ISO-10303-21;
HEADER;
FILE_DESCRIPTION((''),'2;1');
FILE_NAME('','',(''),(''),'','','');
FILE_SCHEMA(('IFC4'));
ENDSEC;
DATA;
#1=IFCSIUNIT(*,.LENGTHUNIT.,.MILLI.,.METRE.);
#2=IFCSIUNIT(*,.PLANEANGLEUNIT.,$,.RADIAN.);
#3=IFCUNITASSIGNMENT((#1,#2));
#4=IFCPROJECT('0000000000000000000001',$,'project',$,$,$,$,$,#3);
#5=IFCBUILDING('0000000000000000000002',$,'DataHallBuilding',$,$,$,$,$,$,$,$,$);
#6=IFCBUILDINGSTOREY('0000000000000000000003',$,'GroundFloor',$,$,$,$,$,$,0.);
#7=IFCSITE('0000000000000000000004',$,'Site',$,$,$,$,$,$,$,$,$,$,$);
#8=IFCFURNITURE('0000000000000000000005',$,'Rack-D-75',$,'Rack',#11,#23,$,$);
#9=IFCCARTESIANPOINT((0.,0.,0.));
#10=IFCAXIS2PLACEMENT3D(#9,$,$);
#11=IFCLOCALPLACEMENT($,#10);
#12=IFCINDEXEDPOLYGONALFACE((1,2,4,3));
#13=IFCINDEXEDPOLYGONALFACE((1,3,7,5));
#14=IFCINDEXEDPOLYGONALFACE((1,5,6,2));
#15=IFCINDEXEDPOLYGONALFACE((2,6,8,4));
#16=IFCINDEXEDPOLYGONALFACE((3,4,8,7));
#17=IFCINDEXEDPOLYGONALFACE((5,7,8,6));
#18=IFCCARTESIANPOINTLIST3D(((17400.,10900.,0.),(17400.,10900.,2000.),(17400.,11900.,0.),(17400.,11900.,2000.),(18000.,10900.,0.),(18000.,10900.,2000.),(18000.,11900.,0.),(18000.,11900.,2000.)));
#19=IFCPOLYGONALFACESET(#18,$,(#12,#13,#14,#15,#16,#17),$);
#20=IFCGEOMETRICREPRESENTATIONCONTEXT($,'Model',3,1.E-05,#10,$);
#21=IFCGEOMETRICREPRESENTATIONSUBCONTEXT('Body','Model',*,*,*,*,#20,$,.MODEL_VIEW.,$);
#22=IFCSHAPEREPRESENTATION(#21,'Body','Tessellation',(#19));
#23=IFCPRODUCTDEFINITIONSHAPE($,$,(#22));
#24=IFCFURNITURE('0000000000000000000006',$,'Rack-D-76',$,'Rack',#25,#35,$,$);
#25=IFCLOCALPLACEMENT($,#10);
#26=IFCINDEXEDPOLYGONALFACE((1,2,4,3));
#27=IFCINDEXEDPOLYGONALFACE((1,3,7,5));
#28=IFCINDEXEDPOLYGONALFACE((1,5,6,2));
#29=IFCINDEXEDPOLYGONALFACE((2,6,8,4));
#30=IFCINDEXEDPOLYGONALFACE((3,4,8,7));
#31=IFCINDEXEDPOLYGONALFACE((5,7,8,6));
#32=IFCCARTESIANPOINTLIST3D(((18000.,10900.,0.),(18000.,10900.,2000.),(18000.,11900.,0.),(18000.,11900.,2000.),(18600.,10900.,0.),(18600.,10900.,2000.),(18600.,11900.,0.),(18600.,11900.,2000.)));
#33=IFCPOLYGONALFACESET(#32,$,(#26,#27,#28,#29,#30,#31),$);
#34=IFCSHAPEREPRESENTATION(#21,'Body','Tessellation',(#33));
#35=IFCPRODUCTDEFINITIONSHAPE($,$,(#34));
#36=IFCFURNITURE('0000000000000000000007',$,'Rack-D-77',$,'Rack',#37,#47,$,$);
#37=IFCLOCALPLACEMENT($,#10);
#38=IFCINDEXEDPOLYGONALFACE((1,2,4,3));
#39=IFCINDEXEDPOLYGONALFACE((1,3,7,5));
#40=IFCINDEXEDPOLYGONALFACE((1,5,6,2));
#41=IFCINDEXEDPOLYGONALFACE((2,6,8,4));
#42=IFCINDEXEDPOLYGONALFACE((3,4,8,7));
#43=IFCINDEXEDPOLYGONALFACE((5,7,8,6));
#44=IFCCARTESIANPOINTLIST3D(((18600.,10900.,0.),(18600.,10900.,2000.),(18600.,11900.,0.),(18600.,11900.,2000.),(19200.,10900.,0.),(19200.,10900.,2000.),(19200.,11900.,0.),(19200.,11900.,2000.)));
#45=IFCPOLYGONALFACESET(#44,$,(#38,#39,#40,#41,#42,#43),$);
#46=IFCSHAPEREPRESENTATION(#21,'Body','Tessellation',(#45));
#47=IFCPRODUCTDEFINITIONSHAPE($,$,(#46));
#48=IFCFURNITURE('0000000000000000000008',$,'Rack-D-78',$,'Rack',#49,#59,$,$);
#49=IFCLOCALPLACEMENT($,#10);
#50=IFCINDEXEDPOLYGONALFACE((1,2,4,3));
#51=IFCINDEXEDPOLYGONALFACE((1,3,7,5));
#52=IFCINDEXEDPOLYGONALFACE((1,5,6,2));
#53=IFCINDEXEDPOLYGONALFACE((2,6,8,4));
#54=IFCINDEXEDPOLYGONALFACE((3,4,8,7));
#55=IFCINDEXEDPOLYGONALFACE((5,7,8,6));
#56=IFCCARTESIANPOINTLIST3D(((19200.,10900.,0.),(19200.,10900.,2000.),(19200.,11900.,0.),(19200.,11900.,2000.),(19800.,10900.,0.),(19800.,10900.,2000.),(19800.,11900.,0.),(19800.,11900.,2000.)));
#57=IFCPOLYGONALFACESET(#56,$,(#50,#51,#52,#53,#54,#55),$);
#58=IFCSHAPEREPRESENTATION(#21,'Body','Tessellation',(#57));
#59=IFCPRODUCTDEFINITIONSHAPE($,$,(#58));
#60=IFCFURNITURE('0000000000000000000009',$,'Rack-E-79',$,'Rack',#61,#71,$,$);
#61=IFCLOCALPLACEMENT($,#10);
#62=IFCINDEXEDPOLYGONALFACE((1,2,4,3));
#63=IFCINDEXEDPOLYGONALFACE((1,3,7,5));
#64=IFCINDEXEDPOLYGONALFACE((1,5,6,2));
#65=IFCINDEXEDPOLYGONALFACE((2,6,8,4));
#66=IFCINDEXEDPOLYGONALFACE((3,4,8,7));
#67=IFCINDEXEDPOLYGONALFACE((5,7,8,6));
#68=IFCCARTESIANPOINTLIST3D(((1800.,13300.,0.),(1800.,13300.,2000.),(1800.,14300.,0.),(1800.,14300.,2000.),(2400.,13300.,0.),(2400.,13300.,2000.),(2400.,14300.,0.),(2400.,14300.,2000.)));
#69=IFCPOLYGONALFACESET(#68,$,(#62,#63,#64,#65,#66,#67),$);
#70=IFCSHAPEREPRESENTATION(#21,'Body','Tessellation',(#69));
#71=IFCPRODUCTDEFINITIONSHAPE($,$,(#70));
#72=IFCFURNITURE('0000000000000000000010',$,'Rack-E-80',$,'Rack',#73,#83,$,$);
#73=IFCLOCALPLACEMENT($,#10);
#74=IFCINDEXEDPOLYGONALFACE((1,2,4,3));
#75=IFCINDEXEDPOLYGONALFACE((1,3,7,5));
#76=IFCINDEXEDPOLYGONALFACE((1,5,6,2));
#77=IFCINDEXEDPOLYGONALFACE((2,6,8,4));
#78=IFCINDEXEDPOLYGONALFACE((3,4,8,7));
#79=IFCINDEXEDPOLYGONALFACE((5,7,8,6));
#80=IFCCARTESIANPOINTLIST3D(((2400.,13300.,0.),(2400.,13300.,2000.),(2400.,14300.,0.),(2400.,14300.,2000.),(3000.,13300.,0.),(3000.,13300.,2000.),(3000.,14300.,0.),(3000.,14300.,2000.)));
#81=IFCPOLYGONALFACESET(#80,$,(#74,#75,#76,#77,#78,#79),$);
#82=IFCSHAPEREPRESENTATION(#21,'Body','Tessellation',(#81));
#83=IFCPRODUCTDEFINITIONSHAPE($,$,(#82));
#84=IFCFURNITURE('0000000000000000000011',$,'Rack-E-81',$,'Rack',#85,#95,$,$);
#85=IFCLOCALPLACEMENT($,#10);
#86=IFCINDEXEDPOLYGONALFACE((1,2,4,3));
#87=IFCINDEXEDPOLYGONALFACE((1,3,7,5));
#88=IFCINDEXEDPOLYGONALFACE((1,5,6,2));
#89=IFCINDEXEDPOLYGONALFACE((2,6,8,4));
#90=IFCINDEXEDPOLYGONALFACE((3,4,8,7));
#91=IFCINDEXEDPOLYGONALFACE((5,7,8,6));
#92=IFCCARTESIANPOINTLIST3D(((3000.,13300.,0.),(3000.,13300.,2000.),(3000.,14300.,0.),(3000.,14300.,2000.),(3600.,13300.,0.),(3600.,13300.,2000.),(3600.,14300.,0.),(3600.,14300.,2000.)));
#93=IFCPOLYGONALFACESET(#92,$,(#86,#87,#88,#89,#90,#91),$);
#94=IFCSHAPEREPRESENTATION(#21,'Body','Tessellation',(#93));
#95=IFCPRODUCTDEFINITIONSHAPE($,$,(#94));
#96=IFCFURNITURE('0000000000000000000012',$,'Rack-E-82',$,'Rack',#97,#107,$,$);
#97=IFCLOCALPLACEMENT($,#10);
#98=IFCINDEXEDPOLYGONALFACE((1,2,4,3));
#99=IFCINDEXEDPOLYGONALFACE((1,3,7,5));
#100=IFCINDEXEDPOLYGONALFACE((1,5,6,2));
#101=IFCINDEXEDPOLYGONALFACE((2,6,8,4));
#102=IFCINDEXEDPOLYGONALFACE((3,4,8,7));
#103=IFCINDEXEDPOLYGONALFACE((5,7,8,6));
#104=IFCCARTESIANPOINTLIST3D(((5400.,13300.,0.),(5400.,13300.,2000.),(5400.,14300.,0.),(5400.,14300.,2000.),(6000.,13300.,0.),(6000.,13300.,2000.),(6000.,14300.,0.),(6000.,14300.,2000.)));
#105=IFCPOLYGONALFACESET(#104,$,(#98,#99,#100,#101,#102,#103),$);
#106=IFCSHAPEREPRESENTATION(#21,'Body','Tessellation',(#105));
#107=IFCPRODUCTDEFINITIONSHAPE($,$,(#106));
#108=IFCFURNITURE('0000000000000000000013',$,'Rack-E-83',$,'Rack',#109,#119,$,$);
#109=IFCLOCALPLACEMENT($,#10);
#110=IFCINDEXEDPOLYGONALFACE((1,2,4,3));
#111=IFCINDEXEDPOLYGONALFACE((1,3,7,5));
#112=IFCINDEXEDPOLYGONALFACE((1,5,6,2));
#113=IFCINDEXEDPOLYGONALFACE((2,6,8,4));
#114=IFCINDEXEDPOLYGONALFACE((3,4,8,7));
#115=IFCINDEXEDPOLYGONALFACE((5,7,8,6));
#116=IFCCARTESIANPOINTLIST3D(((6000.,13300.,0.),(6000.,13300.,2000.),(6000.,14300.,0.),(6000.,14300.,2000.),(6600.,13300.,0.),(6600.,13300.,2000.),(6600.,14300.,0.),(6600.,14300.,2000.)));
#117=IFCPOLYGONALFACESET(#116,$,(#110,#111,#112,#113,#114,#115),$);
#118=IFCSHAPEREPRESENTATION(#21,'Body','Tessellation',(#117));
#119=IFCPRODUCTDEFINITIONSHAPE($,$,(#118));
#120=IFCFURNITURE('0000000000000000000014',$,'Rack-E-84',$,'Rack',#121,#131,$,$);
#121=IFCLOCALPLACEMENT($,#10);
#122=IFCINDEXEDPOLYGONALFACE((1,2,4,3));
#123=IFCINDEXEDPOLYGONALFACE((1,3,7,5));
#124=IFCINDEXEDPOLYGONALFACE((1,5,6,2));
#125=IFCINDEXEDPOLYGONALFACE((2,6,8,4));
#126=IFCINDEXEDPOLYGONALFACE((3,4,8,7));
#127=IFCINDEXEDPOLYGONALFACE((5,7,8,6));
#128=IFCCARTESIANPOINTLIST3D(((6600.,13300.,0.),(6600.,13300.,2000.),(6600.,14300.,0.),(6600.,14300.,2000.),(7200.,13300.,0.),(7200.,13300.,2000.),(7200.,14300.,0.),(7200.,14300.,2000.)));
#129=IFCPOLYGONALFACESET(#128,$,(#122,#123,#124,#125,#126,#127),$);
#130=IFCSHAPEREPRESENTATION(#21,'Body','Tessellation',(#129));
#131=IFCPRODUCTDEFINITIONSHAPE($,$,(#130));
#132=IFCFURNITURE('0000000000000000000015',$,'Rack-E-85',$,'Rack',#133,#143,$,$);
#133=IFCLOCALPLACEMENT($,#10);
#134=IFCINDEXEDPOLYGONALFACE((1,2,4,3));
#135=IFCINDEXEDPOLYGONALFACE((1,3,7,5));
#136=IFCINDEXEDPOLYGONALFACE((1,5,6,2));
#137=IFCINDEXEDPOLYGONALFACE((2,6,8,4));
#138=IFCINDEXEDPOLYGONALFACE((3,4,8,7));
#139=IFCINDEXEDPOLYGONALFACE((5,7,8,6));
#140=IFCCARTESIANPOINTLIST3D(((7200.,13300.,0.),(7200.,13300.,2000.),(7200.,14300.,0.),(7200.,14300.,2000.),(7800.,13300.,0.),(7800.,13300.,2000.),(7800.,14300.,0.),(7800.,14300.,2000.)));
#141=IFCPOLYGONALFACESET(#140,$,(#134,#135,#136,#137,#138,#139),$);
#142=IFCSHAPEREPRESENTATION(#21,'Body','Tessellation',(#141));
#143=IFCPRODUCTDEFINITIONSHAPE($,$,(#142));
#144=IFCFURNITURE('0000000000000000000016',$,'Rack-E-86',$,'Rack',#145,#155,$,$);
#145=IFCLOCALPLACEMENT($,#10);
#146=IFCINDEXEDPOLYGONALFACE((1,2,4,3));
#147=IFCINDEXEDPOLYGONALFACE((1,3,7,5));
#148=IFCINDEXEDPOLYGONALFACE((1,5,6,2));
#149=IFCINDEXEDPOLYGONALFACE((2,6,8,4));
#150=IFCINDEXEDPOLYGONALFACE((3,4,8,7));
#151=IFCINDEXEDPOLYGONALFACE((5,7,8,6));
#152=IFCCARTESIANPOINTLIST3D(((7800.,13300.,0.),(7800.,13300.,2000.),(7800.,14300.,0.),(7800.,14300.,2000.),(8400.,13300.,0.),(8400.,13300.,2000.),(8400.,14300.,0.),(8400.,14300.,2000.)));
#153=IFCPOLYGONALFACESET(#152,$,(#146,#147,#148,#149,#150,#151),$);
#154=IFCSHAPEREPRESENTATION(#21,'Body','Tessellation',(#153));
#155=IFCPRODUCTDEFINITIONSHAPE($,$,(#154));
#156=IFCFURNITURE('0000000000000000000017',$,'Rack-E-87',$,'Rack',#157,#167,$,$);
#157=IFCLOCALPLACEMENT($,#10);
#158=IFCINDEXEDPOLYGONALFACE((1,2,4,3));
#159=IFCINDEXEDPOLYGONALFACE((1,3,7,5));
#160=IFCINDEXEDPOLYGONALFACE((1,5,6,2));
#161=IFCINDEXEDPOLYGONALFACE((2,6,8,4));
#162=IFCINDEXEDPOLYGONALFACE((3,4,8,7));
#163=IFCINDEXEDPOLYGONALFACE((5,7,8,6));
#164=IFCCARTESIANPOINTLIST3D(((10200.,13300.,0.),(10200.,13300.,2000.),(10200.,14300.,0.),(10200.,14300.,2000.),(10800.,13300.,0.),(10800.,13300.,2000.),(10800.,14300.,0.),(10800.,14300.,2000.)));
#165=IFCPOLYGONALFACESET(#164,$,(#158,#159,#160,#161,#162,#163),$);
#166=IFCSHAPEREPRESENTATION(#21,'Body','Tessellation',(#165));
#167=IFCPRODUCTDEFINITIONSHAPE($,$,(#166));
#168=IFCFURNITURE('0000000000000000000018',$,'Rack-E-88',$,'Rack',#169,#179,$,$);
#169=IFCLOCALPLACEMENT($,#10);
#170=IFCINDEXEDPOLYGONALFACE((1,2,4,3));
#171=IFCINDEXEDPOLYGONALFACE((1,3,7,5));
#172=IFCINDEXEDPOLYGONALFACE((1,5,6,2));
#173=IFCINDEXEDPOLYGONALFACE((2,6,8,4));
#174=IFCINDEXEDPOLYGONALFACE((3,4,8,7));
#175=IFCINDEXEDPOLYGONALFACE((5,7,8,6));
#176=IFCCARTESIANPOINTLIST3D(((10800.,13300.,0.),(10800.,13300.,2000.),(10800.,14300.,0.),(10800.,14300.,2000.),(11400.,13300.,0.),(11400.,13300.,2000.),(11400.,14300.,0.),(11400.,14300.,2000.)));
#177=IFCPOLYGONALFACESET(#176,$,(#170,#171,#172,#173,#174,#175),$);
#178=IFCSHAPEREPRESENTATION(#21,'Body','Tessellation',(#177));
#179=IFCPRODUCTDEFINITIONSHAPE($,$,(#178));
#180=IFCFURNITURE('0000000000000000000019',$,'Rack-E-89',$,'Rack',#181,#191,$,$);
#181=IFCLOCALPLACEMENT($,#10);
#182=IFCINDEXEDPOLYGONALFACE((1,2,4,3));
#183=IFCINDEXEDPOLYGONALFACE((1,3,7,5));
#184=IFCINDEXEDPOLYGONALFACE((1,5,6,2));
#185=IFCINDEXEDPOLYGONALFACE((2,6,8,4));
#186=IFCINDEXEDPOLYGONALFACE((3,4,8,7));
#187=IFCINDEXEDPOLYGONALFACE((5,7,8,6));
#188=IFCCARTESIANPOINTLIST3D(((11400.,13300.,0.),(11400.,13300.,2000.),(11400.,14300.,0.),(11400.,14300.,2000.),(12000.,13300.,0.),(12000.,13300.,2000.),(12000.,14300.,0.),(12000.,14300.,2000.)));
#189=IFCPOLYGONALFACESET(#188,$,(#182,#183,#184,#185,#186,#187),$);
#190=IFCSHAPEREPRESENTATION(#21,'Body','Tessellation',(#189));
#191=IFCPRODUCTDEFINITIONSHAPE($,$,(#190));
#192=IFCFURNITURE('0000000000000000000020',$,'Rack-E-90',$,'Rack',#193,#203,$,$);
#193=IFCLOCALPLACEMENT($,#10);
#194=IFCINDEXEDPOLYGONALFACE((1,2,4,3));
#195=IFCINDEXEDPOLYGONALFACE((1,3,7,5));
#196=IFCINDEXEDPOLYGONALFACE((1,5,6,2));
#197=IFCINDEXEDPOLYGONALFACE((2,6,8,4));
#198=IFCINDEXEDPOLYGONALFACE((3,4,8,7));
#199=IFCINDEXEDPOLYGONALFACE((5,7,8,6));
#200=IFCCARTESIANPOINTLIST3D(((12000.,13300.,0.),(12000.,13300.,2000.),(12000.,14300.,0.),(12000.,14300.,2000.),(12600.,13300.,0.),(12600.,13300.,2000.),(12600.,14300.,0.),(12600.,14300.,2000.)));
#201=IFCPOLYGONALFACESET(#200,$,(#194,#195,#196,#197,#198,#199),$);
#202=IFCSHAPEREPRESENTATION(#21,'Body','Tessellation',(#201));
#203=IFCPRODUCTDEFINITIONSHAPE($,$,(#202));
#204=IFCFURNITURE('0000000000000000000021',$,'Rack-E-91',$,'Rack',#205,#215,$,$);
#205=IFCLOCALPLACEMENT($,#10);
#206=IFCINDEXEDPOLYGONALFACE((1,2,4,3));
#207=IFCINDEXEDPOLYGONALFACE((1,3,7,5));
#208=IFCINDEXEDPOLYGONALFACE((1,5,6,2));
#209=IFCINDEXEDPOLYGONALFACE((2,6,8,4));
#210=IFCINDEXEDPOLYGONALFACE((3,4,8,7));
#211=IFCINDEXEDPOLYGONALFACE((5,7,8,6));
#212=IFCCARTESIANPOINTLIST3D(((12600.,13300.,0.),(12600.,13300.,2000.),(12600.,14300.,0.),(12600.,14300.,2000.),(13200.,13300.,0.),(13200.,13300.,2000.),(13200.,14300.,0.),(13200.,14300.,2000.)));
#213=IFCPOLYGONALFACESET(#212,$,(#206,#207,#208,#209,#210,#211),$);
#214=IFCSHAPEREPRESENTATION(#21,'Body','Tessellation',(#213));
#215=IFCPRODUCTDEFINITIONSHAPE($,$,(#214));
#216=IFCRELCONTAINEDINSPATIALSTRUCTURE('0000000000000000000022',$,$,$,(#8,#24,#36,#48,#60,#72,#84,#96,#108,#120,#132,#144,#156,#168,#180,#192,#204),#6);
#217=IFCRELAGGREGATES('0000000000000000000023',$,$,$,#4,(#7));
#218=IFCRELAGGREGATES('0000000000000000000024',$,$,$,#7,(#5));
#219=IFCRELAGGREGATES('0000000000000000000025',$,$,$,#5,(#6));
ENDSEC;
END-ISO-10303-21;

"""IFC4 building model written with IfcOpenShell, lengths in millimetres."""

from ifc_helpers import new_model, si_unit, frame, origin, place, context, subcontext, project, spatial, rectangle, extrude, element, save


model = new_model("IFC4")

# Units and contexts
model_context = context("Model", 3, precision=1e-05, world=origin())
body_context = subcontext(model_context, "Body", "Model", "MODEL_VIEW")
ifc_project = project(units=[si_unit("LENGTHUNIT", "METRE", prefix="MILLI"), si_unit("PLANEANGLEUNIT", "RADIAN")])

# Site, building, storey
site = spatial("IfcSite", under=ifc_project, Name="Site")
building = spatial("IfcBuilding", under=site, Name="DataHallBuilding")
storey = spatial("IfcBuildingStorey", under=building, Name="GroundFloor", Elevation=0.0)

# Furniture
furniture_1_placement = place(None, origin())
element("IfcFurniture", 1, at=furniture_1_placement, inside=storey, Name="Rack-D-75", ObjectType="Rack", context=body_context, shape_type="SweptSolid", body=[
    extrude(rectangle(XDim=600.0, YDim=1000.0), frame((17700.0, 11400.0, 0.0), z_axis=(0.0, 0.0, 1.0), x_axis=(1.0, 0.0, 0.0)), (0.0, 0.0, 1.0), 2000.0),
])
furniture_2_placement = place(None, origin())
element("IfcFurniture", 2, at=furniture_2_placement, inside=storey, Name="Rack-D-76", ObjectType="Rack", context=body_context, shape_type="SweptSolid", body=[
    extrude(rectangle(XDim=600.0, YDim=1000.0), frame((18300.0, 11400.0, 0.0), z_axis=(0.0, 0.0, 1.0), x_axis=(1.0, 0.0, 0.0)), (0.0, 0.0, 1.0), 2000.0),
])
furniture_3_placement = place(None, origin())
element("IfcFurniture", 3, at=furniture_3_placement, inside=storey, Name="Rack-D-77", ObjectType="Rack", context=body_context, shape_type="SweptSolid", body=[
    extrude(rectangle(XDim=600.0, YDim=1000.0), frame((18900.0, 11400.0, 0.0), z_axis=(0.0, 0.0, 1.0), x_axis=(1.0, 0.0, 0.0)), (0.0, 0.0, 1.0), 2000.0),
])
furniture_4_placement = place(None, origin())
element("IfcFurniture", 4, at=furniture_4_placement, inside=storey, Name="Rack-D-78", ObjectType="Rack", context=body_context, shape_type="SweptSolid", body=[
    extrude(rectangle(XDim=600.0, YDim=1000.0), frame((19500.0, 11400.0, 0.0), z_axis=(0.0, 0.0, 1.0), x_axis=(1.0, 0.0, 0.0)), (0.0, 0.0, 1.0), 2000.0),
])
furniture_5_placement = place(None, origin())
element("IfcFurniture", 5, at=furniture_5_placement, inside=storey, Name="Rack-E-79", ObjectType="Rack", context=body_context, shape_type="SweptSolid", body=[
    extrude(rectangle(XDim=600.0, YDim=1000.0), frame((2100.0, 13800.0, 0.0), z_axis=(0.0, 0.0, 1.0), x_axis=(1.0, 0.0, 0.0)), (0.0, 0.0, 1.0), 2000.0),
])
furniture_6_placement = place(None, origin())
element("IfcFurniture", 6, at=furniture_6_placement, inside=storey, Name="Rack-E-80", ObjectType="Rack", context=body_context, shape_type="SweptSolid", body=[
    extrude(rectangle(XDim=600.0, YDim=1000.0), frame((2700.0, 13800.0, 0.0), z_axis=(0.0, 0.0, 1.0), x_axis=(1.0, 0.0, 0.0)), (0.0, 0.0, 1.0), 2000.0),
])
furniture_7_placement = place(None, origin())
element("IfcFurniture", 7, at=furniture_7_placement, inside=storey, Name="Rack-E-81", ObjectType="Rack", context=body_context, shape_type="SweptSolid", body=[
    extrude(rectangle(XDim=600.0, YDim=1000.0), frame((3300.0, 13800.0, 0.0), z_axis=(0.0, 0.0, 1.0), x_axis=(1.0, 0.0, 0.0)), (0.0, 0.0, 1.0), 2000.0),
])
furniture_8_placement = place(None, origin())
element("IfcFurniture", 8, at=furniture_8_placement, inside=storey, Name="Rack-E-82", ObjectType="Rack", context=body_context, shape_type="SweptSolid", body=[
    extrude(rectangle(XDim=600.0, YDim=1000.0), frame((5700.0, 13800.0, 0.0), z_axis=(0.0, 0.0, 1.0), x_axis=(1.0, 0.0, 0.0)), (0.0, 0.0, 1.0), 2000.0),
])
furniture_9_placement = place(None, origin())
element("IfcFurniture", 9, at=furniture_9_placement, inside=storey, Name="Rack-E-83", ObjectType="Rack", context=body_context, shape_type="SweptSolid", body=[
    extrude(rectangle(XDim=600.0, YDim=1000.0), frame((6300.0, 13800.0, 0.0), z_axis=(0.0, 0.0, 1.0), x_axis=(1.0, 0.0, 0.0)), (0.0, 0.0, 1.0), 2000.0),
])
furniture_10_placement = place(None, origin())
element("IfcFurniture", 10, at=furniture_10_placement, inside=storey, Name="Rack-E-84", ObjectType="Rack", context=body_context, shape_type="SweptSolid", body=[
    extrude(rectangle(XDim=600.0, YDim=1000.0), frame((6900.0, 13800.0, 0.0), z_axis=(0.0, 0.0, 1.0), x_axis=(1.0, 0.0, 0.0)), (0.0, 0.0, 1.0), 2000.0),
])
furniture_11_placement = place(None, origin())
element("IfcFurniture", 11, at=furniture_11_placement, inside=storey, Name="Rack-E-85", ObjectType="Rack", context=body_context, shape_type="SweptSolid", body=[
    extrude(rectangle(XDim=600.0, YDim=1000.0), frame((7500.0, 13800.0, 0.0), z_axis=(0.0, 0.0, 1.0), x_axis=(1.0, 0.0, 0.0)), (0.0, 0.0, 1.0), 2000.0),
])
furniture_12_placement = place(None, origin())
element("IfcFurniture", 12, at=furniture_12_placement, inside=storey, Name="Rack-E-86", ObjectType="Rack", context=body_context, shape_type="SweptSolid", body=[
    extrude(rectangle(XDim=600.0, YDim=1000.0), frame((8100.0, 13800.0, 0.0), z_axis=(0.0, 0.0, 1.0), x_axis=(1.0, 0.0, 0.0)), (0.0, 0.0, 1.0), 2000.0),
])
furniture_13_placement = place(None, origin())
element("IfcFurniture", 13, at=furniture_13_placement, inside=storey, Name="Rack-E-87", ObjectType="Rack", context=body_context, shape_type="SweptSolid", body=[
    extrude(rectangle(XDim=600.0, YDim=1000.0), frame((10500.0, 13800.0, 0.0), z_axis=(0.0, 0.0, 1.0), x_axis=(1.0, 0.0, 0.0)), (0.0, 0.0, 1.0), 2000.0),
])
furniture_14_placement = place(None, origin())
element("IfcFurniture", 14, at=furniture_14_placement, inside=storey, Name="Rack-E-88", ObjectType="Rack", context=body_context, shape_type="SweptSolid", body=[
    extrude(rectangle(XDim=600.0, YDim=1000.0), frame((11100.0, 13800.0, 0.0), z_axis=(0.0, 0.0, 1.0), x_axis=(1.0, 0.0, 0.0)), (0.0, 0.0, 1.0), 2000.0),
])
furniture_15_placement = place(None, origin())
element("IfcFurniture", 15, at=furniture_15_placement, inside=storey, Name="Rack-E-89", ObjectType="Rack", context=body_context, shape_type="SweptSolid", body=[
    extrude(rectangle(XDim=600.0, YDim=1000.0), frame((11700.0, 13800.0, 0.0), z_axis=(0.0, 0.0, 1.0), x_axis=(1.0, 0.0, 0.0)), (0.0, 0.0, 1.0), 2000.0),
])
furniture_16_placement = place(None, origin())
element("IfcFurniture", 16, at=furniture_16_placement, inside=storey, Name="Rack-E-90", ObjectType="Rack", context=body_context, shape_type="SweptSolid", body=[
    extrude(rectangle(XDim=600.0, YDim=1000.0), frame((12300.0, 13800.0, 0.0), z_axis=(0.0, 0.0, 1.0), x_axis=(1.0, 0.0, 0.0)), (0.0, 0.0, 1.0), 2000.0),
])
furniture_17_placement = place(None, origin())
element("IfcFurniture", 17, at=furniture_17_placement, inside=storey, Name="Rack-E-91", ObjectType="Rack", context=body_context, shape_type="SweptSolid", body=[
    extrude(rectangle(XDim=600.0, YDim=1000.0), frame((12900.0, 13800.0, 0.0), z_axis=(0.0, 0.0, 1.0), x_axis=(1.0, 0.0, 0.0)), (0.0, 0.0, 1.0), 2000.0),
])

save(model, "model.ifc")
